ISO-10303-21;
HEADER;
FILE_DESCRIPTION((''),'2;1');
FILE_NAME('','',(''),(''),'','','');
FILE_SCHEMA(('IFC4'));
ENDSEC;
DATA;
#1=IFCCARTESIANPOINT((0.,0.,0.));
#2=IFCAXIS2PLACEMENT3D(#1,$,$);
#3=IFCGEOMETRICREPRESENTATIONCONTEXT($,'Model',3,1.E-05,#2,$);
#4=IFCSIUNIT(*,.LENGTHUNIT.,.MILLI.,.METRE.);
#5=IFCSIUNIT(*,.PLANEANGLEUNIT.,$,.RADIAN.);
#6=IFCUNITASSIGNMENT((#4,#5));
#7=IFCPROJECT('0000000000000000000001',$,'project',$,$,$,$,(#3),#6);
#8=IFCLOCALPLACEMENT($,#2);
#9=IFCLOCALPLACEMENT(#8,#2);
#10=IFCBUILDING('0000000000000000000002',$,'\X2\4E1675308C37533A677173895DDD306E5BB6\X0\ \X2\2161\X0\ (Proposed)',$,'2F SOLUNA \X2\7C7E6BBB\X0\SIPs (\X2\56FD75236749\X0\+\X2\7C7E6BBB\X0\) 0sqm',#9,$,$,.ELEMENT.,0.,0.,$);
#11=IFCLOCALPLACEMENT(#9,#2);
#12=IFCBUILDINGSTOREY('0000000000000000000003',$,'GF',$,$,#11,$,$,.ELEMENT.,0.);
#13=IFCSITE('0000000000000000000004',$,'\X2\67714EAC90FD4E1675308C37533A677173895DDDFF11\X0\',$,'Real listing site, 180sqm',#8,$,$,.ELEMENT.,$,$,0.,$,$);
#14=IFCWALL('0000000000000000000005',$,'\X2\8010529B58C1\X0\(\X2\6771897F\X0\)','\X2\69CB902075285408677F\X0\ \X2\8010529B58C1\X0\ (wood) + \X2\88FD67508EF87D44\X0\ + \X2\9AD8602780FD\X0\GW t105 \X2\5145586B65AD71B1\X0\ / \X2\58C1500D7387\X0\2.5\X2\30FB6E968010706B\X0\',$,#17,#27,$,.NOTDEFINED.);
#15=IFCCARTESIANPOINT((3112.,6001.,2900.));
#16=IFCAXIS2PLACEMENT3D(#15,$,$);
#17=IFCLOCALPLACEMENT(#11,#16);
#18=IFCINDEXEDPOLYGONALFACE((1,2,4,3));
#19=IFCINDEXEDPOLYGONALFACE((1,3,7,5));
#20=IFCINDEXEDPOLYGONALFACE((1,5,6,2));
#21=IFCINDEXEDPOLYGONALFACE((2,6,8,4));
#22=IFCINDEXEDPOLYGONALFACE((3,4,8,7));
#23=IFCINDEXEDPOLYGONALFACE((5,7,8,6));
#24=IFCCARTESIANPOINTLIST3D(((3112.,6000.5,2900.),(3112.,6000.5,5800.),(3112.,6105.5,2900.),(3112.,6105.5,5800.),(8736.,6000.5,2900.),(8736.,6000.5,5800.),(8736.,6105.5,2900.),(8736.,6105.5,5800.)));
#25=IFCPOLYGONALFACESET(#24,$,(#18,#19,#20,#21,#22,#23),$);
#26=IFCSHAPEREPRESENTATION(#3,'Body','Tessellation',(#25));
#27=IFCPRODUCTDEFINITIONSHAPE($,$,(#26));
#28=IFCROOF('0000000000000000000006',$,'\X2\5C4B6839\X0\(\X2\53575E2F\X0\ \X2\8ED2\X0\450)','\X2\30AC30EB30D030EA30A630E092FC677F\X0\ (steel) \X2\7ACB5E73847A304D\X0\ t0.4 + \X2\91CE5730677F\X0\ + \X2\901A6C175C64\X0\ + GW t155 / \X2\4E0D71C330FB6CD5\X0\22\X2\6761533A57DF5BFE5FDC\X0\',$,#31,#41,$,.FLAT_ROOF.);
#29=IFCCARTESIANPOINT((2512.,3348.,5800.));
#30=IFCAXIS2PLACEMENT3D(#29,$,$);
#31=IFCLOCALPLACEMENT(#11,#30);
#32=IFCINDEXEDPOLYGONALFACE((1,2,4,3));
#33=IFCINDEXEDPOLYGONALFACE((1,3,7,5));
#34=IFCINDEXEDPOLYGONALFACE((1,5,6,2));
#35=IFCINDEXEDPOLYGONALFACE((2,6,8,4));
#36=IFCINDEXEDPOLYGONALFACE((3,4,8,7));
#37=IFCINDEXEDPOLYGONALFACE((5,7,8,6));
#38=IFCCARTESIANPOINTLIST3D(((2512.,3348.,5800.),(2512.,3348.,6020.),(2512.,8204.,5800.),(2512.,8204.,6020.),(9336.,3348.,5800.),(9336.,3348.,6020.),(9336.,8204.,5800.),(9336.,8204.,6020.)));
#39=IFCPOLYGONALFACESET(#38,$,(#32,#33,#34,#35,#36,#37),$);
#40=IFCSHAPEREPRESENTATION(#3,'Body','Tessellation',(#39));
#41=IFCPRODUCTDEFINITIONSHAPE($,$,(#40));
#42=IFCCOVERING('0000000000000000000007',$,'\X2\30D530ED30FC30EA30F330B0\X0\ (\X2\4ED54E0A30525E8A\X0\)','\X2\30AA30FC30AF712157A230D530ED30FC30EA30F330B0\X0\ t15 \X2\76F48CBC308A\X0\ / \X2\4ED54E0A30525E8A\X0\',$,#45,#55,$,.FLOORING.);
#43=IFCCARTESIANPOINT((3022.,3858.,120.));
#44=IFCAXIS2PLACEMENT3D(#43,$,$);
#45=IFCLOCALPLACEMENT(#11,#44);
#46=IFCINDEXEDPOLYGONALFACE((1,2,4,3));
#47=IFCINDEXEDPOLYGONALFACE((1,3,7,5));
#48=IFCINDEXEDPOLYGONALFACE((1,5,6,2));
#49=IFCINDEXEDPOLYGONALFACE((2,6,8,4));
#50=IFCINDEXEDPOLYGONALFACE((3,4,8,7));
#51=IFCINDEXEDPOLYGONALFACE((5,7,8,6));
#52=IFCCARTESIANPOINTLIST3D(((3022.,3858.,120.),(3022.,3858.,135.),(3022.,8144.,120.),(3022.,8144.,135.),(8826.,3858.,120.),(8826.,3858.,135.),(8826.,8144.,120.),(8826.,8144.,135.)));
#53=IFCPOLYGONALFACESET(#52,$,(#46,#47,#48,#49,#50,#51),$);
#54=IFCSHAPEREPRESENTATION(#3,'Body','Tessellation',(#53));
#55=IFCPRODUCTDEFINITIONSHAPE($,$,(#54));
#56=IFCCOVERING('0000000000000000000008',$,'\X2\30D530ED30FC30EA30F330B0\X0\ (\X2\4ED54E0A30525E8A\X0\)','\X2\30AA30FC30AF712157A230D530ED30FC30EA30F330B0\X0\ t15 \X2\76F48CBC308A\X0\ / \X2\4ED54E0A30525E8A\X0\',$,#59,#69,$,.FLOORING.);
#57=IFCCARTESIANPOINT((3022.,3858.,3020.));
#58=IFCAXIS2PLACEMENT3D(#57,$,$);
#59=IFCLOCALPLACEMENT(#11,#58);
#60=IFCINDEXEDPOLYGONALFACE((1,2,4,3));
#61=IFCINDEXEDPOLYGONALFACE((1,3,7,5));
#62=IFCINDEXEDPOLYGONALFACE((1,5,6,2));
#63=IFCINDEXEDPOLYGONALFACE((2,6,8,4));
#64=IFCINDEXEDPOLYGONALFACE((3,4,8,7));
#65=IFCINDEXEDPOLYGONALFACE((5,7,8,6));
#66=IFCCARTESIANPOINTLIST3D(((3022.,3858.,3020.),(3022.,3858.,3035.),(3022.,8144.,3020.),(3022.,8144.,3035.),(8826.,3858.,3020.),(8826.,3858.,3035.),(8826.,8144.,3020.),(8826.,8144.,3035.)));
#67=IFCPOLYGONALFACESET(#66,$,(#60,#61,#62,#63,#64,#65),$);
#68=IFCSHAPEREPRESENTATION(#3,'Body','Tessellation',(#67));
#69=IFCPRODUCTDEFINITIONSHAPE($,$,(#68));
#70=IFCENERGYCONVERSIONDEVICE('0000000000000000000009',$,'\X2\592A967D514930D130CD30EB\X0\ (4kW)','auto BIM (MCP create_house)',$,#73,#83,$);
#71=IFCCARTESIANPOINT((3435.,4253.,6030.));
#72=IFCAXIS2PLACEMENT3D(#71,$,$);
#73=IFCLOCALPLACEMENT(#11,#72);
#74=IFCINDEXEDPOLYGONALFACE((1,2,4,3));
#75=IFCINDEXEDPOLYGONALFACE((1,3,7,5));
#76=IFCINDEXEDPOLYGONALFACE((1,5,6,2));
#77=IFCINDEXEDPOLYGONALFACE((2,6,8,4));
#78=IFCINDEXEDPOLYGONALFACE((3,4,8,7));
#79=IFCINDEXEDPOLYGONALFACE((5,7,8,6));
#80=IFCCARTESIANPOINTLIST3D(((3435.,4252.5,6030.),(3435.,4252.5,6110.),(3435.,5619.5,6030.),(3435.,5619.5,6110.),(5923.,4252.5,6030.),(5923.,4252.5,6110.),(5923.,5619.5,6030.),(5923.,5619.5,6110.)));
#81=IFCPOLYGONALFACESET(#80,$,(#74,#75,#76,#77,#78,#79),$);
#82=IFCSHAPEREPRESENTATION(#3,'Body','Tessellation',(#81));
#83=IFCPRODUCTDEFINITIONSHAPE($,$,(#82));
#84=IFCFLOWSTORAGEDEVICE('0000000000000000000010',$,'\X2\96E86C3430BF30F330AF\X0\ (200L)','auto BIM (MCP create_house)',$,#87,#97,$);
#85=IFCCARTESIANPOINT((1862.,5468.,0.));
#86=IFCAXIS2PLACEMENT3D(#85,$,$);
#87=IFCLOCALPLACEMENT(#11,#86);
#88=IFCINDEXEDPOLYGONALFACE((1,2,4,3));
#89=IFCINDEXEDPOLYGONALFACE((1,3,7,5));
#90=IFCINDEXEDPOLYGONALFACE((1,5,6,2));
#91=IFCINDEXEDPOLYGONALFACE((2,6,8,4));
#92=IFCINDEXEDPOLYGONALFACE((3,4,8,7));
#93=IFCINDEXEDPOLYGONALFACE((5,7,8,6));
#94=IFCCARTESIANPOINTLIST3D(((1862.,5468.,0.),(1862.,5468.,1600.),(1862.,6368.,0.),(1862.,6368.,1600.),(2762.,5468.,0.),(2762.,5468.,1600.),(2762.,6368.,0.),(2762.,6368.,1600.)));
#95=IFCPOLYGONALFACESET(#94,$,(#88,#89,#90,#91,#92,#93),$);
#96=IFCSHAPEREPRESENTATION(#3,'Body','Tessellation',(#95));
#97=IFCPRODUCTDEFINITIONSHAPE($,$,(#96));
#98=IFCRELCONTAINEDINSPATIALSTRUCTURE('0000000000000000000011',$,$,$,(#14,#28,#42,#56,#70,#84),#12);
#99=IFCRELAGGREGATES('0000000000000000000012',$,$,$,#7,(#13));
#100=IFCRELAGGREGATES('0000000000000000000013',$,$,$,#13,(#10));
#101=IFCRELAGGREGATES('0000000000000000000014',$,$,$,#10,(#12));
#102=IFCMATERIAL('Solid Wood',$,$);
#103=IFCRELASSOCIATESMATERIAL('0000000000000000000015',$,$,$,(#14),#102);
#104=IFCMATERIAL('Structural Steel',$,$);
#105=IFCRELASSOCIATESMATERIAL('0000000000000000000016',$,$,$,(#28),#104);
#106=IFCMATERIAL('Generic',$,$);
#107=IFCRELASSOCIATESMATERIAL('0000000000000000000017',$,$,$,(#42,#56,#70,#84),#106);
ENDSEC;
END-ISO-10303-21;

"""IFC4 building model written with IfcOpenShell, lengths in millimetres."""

from ifc_helpers import new_model, si_unit, frame, frame_2d, origin, place, context, project, spatial, rectangle, extrude, material, element, save


model = new_model("IFC4")

# Units and contexts
model_context = context("Model", 3, precision=1e-05, world=origin())
ifc_project = project(units=[si_unit("LENGTHUNIT", "METRE", prefix="MILLI"), si_unit("PLANEANGLEUNIT", "RADIAN")], contexts=[model_context])

# Site, building, storey
site_placement = place(None, origin())
site = spatial("IfcSite", under=ifc_project, at=site_placement, Name="東京都世田谷区東玉川１", ObjectType="Real listing site, 180sqm", CompositionType="ELEMENT", RefElevation=0.0)
building_placement = place(site_placement, origin())
building = spatial("IfcBuilding", under=site, at=building_placement, Name="世田谷区東玉川の家 Ⅱ (Proposed)", ObjectType="2F SOLUNA 籾殻SIPs (国産杉+籾殻) 0sqm", CompositionType="ELEMENT", ElevationOfRefHeight=0.0, ElevationOfTerrain=0.0)
storey_placement = place(building_placement, origin())
storey = spatial("IfcBuildingStorey", under=building, at=storey_placement, Name="GF", CompositionType="ELEMENT", Elevation=0.0)

# Shared definitions
ifc_material_1 = material(Name="Solid Wood")

# Wall
wall_1_placement = place(storey_placement, frame((3112.0, 6001.0, 2900.0)))
element("IfcWall", 1, at=wall_1_placement, inside=storey, material=ifc_material_1, Name="耐力壁(東西)", Description="構造用合板 耐力壁 (wood) + 製材軸組 + 高性能GW t105 充填断熱 / 壁倍率2.5・準耐火", PredefinedType="NOTDEFINED", context=model_context, shape_type="SweptSolid", body=[
    extrude(rectangle(XDim=5624.0, YDim=105.0, at=frame_2d((2812.0, 52.0))), frame((3112.0, 6001.0, 2900.0)), (0.0, 0.0, 1.0), 2900.0),
])

# Roof
ifc_material_2 = material(Name="Structural Steel")
for number, where, name in (
    (2, (2512.0, 3348.0, 5800.0), "屋根(南帯 軒450)"),
):
    element("IfcRoof", number, at=place(storey_placement, frame(where)), inside=storey, material=ifc_material_2, Name=name, Description="ガルバリウム鋼板 (steel) 立平葺き t0.4 + 野地板 + 通気層 + GW t155 / 不燃・法22条区域対応", PredefinedType="FLAT_ROOF", context=model_context, shape_type="SweptSolid", body=[
        extrude(rectangle(XDim=6824.0, YDim=4856.0, at=frame_2d((3412.0, 2428.0))), frame((2512.0, 3348.0, 5800.0)), (0.0, 0.0, 1.0), 220.0),
    ])

# Coverings
ifc_material_3 = material(Name="Generic")
covering_1_placement = place(storey_placement, frame((3022.0, 3858.0, 120.0)))
element("IfcCovering", 3, at=covering_1_placement, inside=storey, material=ifc_material_3, Name="フローリング (仕上げ床)", Description="オーク無垢フローリング t15 直貼り / 仕上げ床", PredefinedType="FLOORING", context=model_context, shape_type="SweptSolid", body=[
    extrude(rectangle(XDim=5804.0, YDim=4286.0, at=frame_2d((2902.0, 2143.0))), frame((3022.0, 3858.0, 120.0)), (0.0, 0.0, 1.0), 15.0),
])
covering_2_placement = place(storey_placement, frame((3022.0, 3858.0, 3020.0)))
element("IfcCovering", 4, at=covering_2_placement, inside=storey, material=ifc_material_3, Name="フローリング (仕上げ床)", Description="オーク無垢フローリング t15 直貼り / 仕上げ床", PredefinedType="FLOORING", context=model_context, shape_type="SweptSolid", body=[
    extrude(rectangle(XDim=5804.0, YDim=4286.0, at=frame_2d((2902.0, 2143.0))), frame((3022.0, 3858.0, 3020.0)), (0.0, 0.0, 1.0), 15.0),
])

# Energy conversion device
energy_conversion_device_placement = place(storey_placement, frame((3435.0, 4253.0, 6030.0)))
element("IfcEnergyConversionDevice", 5, at=energy_conversion_device_placement, inside=storey, material=ifc_material_3, Name="太陽光パネル (4kW)", Description="auto BIM (MCP create_house)", context=model_context, shape_type="SweptSolid", body=[
    extrude(rectangle(XDim=2488.0, YDim=1367.0, at=frame_2d((1244.0, 683.0))), frame((3435.0, 4253.0, 6030.0)), (0.0, 0.0, 1.0), 80.0),
])

# Flow storage device
flow_storage_device_placement = place(storey_placement, frame((1862.0, 5468.0, 0.0)))
element("IfcFlowStorageDevice", 6, at=flow_storage_device_placement, inside=storey, material=ifc_material_3, Name="雨水タンク (200L)", Description="auto BIM (MCP create_house)", context=model_context, shape_type="SweptSolid", body=[
    extrude(rectangle(XDim=900.0, YDim=900.0, at=frame_2d((450.0, 450.0))), frame((1862.0, 5468.0, 0.0)), (0.0, 0.0, 1.0), 1600.0),
])

save(model, "model.ifc")
